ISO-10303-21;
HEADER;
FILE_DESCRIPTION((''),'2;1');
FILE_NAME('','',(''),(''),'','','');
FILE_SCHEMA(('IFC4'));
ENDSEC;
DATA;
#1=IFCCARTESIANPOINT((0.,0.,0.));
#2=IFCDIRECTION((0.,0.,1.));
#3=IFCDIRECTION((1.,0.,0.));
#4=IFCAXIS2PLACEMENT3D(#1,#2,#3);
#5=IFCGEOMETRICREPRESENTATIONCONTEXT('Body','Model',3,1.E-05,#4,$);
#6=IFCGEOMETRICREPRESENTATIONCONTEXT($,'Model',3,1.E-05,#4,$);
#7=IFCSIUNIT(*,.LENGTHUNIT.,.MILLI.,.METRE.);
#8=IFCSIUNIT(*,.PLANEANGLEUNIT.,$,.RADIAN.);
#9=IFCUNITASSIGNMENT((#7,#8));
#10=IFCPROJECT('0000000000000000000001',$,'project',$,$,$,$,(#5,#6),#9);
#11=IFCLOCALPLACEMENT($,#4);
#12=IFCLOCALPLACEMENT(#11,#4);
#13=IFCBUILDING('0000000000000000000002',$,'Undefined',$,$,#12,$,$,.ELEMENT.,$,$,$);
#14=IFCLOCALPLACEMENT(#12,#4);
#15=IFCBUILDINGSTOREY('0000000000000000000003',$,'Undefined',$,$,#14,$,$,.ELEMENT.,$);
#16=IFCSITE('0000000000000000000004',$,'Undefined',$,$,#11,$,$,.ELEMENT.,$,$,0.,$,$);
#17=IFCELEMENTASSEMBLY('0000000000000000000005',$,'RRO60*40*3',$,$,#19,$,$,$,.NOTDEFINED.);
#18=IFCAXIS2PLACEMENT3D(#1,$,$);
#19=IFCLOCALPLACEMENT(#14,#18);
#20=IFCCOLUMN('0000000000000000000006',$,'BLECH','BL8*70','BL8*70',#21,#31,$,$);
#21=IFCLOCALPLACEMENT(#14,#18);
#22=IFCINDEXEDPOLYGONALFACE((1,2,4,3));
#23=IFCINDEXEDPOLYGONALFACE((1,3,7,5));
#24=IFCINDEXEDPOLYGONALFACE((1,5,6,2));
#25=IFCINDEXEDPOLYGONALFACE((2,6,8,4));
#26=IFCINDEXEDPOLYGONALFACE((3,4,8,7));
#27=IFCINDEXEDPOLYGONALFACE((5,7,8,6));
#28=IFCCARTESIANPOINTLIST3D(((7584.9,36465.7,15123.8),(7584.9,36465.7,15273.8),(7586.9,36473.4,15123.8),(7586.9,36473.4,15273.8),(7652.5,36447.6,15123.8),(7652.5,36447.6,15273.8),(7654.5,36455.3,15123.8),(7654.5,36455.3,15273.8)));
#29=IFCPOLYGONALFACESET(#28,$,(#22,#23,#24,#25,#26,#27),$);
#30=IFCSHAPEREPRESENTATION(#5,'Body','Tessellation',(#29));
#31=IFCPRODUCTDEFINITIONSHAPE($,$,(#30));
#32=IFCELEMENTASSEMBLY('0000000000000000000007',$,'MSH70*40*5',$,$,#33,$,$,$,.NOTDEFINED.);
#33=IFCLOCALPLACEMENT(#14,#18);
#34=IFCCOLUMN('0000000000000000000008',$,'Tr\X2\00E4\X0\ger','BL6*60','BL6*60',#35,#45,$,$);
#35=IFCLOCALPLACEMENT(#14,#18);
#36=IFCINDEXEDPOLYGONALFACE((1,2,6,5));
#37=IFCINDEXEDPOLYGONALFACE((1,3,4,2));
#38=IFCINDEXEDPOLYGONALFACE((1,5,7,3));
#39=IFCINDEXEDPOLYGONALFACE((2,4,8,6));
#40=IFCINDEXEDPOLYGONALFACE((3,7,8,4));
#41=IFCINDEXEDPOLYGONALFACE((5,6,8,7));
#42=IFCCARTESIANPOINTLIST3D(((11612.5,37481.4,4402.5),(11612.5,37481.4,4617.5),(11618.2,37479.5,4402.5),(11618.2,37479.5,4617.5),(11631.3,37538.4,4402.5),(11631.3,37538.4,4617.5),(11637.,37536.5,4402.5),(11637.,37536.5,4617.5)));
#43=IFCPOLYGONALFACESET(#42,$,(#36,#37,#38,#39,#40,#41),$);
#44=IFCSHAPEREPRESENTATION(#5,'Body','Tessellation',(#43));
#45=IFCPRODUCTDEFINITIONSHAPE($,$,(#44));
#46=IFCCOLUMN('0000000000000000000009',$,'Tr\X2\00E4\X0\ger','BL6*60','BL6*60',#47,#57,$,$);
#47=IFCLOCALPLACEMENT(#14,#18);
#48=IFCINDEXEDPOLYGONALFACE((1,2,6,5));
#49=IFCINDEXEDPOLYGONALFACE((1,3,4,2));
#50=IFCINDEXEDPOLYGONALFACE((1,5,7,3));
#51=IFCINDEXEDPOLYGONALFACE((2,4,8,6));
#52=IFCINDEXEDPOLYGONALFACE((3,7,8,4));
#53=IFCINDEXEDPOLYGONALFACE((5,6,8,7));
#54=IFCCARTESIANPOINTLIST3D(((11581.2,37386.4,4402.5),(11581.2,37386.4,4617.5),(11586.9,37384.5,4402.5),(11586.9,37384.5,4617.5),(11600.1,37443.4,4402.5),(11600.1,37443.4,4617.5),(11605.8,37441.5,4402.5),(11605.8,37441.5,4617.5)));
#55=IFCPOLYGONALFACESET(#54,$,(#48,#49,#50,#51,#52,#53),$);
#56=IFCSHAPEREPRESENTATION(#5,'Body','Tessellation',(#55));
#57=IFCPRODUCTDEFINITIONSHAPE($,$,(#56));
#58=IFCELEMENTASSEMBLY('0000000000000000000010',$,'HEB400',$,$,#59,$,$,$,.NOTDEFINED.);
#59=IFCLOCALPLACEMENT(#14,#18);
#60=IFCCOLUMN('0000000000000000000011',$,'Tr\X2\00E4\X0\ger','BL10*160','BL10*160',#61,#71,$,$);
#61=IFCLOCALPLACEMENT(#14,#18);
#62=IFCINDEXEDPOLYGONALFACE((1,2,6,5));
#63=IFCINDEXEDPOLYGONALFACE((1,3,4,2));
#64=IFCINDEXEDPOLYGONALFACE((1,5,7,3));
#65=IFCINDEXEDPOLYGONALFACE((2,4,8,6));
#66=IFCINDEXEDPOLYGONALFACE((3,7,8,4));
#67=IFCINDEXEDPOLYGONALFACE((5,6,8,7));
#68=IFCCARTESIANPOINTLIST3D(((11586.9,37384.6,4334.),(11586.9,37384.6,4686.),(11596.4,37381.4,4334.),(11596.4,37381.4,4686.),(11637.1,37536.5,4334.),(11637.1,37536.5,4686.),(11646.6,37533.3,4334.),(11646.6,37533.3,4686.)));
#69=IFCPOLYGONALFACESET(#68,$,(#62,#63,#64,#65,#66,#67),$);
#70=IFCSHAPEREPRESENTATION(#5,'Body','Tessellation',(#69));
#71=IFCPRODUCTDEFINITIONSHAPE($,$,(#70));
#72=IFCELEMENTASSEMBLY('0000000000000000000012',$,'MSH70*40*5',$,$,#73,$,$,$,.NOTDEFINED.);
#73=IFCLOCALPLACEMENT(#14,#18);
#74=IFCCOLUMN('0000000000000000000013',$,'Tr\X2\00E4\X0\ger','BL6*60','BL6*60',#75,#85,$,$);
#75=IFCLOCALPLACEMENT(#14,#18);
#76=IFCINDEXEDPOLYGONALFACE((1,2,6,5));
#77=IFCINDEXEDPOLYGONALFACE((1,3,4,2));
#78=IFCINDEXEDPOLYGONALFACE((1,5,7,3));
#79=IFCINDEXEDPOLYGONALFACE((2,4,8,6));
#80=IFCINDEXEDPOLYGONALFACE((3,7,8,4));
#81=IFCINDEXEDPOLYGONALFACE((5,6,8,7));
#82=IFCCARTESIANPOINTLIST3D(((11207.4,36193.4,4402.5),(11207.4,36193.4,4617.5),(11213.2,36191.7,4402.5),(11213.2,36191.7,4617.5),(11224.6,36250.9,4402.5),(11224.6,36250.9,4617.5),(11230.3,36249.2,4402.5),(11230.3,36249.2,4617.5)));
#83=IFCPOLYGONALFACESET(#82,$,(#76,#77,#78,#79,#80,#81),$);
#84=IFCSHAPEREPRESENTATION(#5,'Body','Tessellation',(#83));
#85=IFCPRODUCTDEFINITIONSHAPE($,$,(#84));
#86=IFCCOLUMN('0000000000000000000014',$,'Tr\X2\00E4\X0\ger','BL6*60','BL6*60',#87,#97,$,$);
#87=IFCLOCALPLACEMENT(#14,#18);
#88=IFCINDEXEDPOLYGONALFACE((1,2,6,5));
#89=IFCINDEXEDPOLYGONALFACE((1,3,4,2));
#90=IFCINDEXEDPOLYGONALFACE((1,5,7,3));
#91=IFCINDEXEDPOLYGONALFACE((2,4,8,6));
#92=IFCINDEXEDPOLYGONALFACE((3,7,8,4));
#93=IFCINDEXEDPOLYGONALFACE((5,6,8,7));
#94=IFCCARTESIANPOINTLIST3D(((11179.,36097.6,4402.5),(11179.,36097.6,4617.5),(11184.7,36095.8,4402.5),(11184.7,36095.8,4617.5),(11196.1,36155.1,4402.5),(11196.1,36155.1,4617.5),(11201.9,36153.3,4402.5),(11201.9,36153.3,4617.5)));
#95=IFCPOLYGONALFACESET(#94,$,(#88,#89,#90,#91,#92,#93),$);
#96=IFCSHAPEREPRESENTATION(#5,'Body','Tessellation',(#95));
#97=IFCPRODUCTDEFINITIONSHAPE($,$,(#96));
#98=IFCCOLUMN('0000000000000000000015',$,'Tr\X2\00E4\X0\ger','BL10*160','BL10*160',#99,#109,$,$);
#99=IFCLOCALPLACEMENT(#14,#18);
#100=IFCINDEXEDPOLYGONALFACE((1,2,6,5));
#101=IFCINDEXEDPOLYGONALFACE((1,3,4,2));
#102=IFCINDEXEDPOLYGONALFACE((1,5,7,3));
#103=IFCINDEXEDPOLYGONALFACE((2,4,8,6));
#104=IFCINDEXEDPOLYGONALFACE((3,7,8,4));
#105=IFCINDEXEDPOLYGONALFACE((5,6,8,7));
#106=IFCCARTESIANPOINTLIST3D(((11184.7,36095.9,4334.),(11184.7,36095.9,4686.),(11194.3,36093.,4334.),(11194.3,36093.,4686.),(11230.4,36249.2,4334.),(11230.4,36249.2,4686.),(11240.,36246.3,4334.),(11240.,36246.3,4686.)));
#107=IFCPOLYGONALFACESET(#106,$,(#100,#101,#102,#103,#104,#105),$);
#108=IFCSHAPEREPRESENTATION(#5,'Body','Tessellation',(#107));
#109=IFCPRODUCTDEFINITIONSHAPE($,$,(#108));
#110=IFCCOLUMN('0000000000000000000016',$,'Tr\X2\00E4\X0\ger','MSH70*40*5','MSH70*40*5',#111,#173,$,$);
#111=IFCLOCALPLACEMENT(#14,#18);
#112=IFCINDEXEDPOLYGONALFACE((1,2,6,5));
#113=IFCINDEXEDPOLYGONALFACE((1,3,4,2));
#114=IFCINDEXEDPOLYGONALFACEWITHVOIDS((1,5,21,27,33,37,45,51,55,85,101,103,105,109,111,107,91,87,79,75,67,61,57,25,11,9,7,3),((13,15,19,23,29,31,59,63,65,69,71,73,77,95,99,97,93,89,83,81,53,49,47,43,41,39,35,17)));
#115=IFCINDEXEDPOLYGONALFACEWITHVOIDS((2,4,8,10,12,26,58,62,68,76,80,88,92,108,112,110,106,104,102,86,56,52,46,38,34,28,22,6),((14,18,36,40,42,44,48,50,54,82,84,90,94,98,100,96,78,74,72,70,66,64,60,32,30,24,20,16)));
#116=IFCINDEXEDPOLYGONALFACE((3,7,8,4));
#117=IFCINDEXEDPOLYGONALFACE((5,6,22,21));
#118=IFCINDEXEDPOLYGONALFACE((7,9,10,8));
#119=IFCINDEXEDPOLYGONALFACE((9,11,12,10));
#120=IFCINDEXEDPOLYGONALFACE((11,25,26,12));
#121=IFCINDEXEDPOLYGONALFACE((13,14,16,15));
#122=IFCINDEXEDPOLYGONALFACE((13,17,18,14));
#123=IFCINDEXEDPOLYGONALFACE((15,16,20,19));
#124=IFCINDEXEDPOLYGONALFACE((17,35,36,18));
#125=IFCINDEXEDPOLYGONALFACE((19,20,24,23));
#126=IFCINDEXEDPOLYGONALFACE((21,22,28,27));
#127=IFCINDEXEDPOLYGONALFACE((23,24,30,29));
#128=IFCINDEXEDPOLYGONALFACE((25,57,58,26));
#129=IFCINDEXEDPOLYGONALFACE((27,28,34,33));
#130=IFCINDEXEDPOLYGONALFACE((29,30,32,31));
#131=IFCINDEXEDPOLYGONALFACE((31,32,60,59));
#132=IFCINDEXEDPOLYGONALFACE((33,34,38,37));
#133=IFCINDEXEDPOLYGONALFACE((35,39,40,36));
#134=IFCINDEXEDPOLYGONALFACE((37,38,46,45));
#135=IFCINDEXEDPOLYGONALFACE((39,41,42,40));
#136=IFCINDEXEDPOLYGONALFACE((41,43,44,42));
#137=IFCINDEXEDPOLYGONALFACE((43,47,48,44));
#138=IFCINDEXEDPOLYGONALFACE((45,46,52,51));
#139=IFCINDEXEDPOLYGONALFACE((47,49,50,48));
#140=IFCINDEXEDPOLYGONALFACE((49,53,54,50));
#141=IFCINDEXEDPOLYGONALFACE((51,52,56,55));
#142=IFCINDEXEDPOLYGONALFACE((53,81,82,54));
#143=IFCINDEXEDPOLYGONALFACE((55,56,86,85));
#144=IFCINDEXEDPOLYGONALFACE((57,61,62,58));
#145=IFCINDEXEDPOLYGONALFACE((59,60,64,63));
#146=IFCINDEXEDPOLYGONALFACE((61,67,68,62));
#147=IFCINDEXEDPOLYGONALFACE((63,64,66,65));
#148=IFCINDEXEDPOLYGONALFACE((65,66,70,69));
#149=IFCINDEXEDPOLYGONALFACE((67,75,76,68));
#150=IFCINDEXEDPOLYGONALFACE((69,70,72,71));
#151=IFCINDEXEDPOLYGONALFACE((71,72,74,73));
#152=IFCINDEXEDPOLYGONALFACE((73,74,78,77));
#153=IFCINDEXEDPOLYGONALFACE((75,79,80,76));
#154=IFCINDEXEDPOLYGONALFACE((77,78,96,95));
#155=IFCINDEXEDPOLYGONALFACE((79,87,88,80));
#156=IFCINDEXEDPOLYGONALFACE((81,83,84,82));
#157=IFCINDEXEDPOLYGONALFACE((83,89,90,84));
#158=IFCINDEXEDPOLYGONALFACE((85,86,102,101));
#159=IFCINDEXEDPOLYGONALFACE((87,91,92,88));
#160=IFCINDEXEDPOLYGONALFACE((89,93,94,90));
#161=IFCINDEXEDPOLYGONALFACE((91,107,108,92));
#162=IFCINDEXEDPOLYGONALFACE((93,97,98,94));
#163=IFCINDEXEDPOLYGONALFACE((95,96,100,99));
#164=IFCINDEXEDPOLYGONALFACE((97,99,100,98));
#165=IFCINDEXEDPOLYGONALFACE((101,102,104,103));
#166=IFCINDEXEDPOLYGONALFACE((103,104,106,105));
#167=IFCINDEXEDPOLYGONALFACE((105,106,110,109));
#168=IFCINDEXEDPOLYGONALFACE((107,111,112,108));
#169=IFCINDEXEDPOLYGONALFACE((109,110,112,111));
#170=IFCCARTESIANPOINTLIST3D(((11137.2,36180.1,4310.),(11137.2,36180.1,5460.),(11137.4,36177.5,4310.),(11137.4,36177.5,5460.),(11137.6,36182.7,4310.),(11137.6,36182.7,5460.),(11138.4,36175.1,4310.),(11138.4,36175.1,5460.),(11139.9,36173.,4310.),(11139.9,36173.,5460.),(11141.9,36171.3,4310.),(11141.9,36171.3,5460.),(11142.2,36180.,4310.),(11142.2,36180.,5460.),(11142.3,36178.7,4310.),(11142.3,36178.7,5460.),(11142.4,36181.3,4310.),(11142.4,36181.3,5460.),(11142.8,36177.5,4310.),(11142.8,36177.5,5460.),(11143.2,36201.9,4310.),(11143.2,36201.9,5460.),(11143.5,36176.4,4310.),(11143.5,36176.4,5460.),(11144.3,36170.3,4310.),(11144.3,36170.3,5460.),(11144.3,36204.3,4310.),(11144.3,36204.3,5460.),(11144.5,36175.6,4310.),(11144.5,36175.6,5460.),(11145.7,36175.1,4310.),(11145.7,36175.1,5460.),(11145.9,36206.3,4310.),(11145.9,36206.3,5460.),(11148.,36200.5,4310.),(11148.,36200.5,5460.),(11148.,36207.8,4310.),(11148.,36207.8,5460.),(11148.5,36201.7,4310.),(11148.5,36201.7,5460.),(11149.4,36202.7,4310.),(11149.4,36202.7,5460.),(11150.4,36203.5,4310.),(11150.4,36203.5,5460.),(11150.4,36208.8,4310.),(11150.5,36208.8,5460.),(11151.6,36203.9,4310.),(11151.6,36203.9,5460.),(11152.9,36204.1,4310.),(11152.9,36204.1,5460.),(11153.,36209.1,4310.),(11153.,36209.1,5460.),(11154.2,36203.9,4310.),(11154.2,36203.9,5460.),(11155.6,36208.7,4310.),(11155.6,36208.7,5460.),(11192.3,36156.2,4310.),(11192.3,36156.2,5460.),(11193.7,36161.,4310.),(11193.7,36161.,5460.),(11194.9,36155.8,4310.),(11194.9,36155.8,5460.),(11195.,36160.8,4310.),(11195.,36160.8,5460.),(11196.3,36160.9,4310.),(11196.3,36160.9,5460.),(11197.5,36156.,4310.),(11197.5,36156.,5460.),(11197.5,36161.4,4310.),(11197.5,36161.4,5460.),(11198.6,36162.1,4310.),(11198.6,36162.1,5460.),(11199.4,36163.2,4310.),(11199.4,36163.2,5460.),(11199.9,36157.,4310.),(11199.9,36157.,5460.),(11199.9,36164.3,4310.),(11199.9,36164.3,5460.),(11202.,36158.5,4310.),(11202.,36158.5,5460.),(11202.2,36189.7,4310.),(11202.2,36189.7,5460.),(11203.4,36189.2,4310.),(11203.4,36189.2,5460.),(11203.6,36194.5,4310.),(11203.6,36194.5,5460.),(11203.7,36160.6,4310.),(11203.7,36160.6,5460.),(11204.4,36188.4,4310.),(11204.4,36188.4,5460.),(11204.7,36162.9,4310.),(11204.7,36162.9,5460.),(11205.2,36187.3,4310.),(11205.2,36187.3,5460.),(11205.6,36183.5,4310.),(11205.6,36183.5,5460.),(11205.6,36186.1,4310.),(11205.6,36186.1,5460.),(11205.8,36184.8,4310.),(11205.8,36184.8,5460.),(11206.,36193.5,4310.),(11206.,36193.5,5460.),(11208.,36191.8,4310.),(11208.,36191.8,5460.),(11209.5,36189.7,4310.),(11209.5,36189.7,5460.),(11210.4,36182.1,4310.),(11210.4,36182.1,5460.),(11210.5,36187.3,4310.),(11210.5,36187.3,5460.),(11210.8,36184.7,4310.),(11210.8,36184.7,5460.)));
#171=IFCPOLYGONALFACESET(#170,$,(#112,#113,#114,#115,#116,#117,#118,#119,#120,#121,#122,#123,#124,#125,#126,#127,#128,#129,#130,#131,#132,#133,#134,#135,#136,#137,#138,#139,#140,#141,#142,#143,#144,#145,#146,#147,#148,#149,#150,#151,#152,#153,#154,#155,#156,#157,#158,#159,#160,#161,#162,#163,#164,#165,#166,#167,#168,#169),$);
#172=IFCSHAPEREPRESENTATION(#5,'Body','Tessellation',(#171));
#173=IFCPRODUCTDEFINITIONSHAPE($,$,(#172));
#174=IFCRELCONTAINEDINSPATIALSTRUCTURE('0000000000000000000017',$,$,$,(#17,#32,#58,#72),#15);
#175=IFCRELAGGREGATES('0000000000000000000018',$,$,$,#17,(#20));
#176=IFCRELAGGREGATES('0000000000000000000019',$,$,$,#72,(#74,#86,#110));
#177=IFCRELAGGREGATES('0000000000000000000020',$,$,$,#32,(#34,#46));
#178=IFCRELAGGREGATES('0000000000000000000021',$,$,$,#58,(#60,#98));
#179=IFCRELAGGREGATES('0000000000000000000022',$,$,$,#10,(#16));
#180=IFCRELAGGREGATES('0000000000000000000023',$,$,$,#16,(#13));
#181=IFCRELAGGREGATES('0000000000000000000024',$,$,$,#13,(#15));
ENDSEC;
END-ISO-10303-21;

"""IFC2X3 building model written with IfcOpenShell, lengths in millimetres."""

from ifc_helpers import new_model, si_unit, frame, origin_with_axes, origin_2d_with_axis, place, context, project, spatial, rectangle, hollow_rectangle, extrude, element, aggregate, save


model = new_model("IFC2X3")

# Units and contexts
model_context_1 = context("Model", 3, precision=1e-05, world=origin_with_axes(), identifier="Body")
model_context_2 = context("Model", 3, precision=1e-05, world=origin_with_axes())
ifc_project = project(units=[si_unit("LENGTHUNIT", "METRE", prefix="MILLI"), si_unit("PLANEANGLEUNIT", "RADIAN")], contexts=[model_context_1, model_context_2])

# Site, building, storey
site_placement = place(None, origin_with_axes())
site = spatial("IfcSite", under=ifc_project, at=site_placement, Name="Undefined", CompositionType="ELEMENT", RefElevation=0.0)
building_placement = place(site_placement, origin_with_axes())
building = spatial("IfcBuilding", under=site, at=building_placement, Name="Undefined", CompositionType="ELEMENT")
storey_placement = place(building_placement, origin_with_axes())
storey = spatial("IfcBuildingStorey", under=building, at=storey_placement, Name="Undefined", CompositionType="ELEMENT")

# Element assembly, column
assembly_1 = element("IfcElementAssembly", 1, inside=storey, Name="RRO60*40*3", PredefinedType="NOTDEFINED")
column_1_placement = place(storey_placement, frame((7619.7, 36460.5, 15123.8), z_axis=(0.0, 0.0, 1.0), x_axis=(1.0, 0.0, 0.0)))
column_1 = element("IfcColumn", 2, at=column_1_placement, Name="BLECH", Description="BL8*70", ObjectType="BL8*70", context=model_context_1, shape_type="SweptSolid", body=[
    extrude(rectangle(XDim=8.0, YDim=70.0, at=origin_2d_with_axis()), frame((0.0, 0.0, 150.0), z_axis=(0.0, 0.0, -1.0), x_axis=(-0.25876, -0.965942, 0.000006)), (0.0, 0.0, 1.0), 150.0),
])
aggregate(assembly_1, [column_1])

# Element assembly, columns
assembly_2 = element("IfcElementAssembly", 3, inside=storey, Name="MSH70*40*5", PredefinedType="NOTDEFINED")
column_2_placement = place(storey_placement, frame((11624.8, 37508.9, 4402.5), z_axis=(0.0, 0.0, 1.0), x_axis=(1.0, 0.0, 0.0)))
column_2 = element("IfcColumn", 4, at=column_2_placement, Name="Träger", Description="BL6*60", ObjectType="BL6*60", context=model_context_1, shape_type="SweptSolid", body=[
    extrude(rectangle(XDim=6.0, YDim=60.0, at=origin_2d_with_axis()), frame((0.0, 0.0, 215.0), z_axis=(0.0, 0.0, -1.0), x_axis=(-0.949425, 0.313992, 0.0)), (0.0, 0.0, 1.0), 215.0),
])
column_3_placement = place(storey_placement, frame((11593.5, 37414.0, 4402.5), z_axis=(0.0, 0.0, 1.0), x_axis=(1.0, 0.0, 0.0)))
column_3 = element("IfcColumn", 5, at=column_3_placement, Name="Träger", Description="BL6*60", ObjectType="BL6*60", context=model_context_1, shape_type="SweptSolid", body=[
    extrude(rectangle(XDim=6.0, YDim=60.0, at=origin_2d_with_axis()), frame((0.0, 0.0, 215.0), z_axis=(0.0, 0.0, -1.0), x_axis=(-0.949425, 0.313992, 0.0)), (0.0, 0.0, 1.0), 215.0),
])

# Element assembly, column
assembly_3 = element("IfcElementAssembly", 6, inside=storey, Name="HEB400", PredefinedType="NOTDEFINED")
column_4_placement = place(storey_placement, frame((11616.7, 37458.9, 4334.0), z_axis=(0.0, 0.0, 1.0), x_axis=(1.0, 0.0, 0.0)))
column_4 = element("IfcColumn", 7, at=column_4_placement, Name="Träger", Description="BL10*160", ObjectType="BL10*160", context=model_context_1, shape_type="SweptSolid", body=[
    extrude(rectangle(XDim=10.0, YDim=160.0, at=origin_2d_with_axis()), frame((0.0, 0.0, 352.0), z_axis=(0.0, 0.0, -1.0), x_axis=(-0.949425, 0.313992, 0.0)), (0.0, 0.0, 1.0), 352.0),
])

# Element assembly, columns
assembly_4 = element("IfcElementAssembly", 8, inside=storey, Name="MSH70*40*5", PredefinedType="NOTDEFINED")
column_5_placement = place(storey_placement, frame((11218.9, 36221.3, 4402.5), z_axis=(0.0, 0.0, 1.0), x_axis=(1.0, 0.0, 0.0)))
column_5 = element("IfcColumn", 9, at=column_5_placement, Name="Träger", Description="BL6*60", ObjectType="BL6*60", context=model_context_1, shape_type="SweptSolid", body=[
    extrude(rectangle(XDim=6.0, YDim=60.0, at=origin_2d_with_axis()), frame((0.0, 0.0, 215.0), z_axis=(0.0, 0.0, -1.0), x_axis=(-0.958323, 0.285688, 0.0)), (0.0, 0.0, 1.0), 215.0),
])
column_6_placement = place(storey_placement, frame((11190.4, 36125.5, 4402.5), z_axis=(0.0, 0.0, 1.0), x_axis=(1.0, 0.0, 0.0)))
column_6 = element("IfcColumn", 10, at=column_6_placement, Name="Träger", Description="BL6*60", ObjectType="BL6*60", context=model_context_1, shape_type="SweptSolid", body=[
    extrude(rectangle(XDim=6.0, YDim=60.0, at=origin_2d_with_axis()), frame((0.0, 0.0, 215.0), z_axis=(0.0, 0.0, -1.0), x_axis=(-0.958323, 0.285688, 0.0)), (0.0, 0.0, 1.0), 215.0),
])

# Columns
column_7_placement = place(storey_placement, frame((11212.3, 36171.1, 4334.0), z_axis=(0.0, 0.0, 1.0), x_axis=(1.0, 0.0, 0.0)))
column_7 = element("IfcColumn", 11, at=column_7_placement, Name="Träger", Description="BL10*160", ObjectType="BL10*160", context=model_context_1, shape_type="SweptSolid", body=[
    extrude(rectangle(XDim=10.0, YDim=160.0, at=origin_2d_with_axis()), frame((0.0, 0.0, 352.0), z_axis=(0.0, 0.0, -1.0), x_axis=(-0.958323, 0.285688, 0.0)), (0.0, 0.0, 1.0), 352.0),
])
column_8_placement = place(storey_placement, frame((11174.0, 36182.4, 4310.0), z_axis=(0.0, 0.0, 1.0), x_axis=(1.0, 0.0, 0.0)))
column_8 = element("IfcColumn", 12, at=column_8_placement, Name="Träger", Description="MSH70*40*5", ObjectType="MSH70*40*5", context=model_context_1, shape_type="SweptSolid", body=[
    extrude(hollow_rectangle(XDim=40.0, YDim=70.0, WallThickness=5.0, InnerFilletRadius=5.0, OuterFilletRadius=10.0, at=origin_2d_with_axis()), frame((0.0, 0.0, 1150.0), z_axis=(0.0, 0.0, -1.0), x_axis=(-0.282341, -0.959314, 0.0)), (0.0, 0.0, 1.0), 1150.0),
])
aggregate(assembly_4, [column_5, column_6, column_8])
aggregate(assembly_2, [column_2, column_3])
aggregate(assembly_3, [column_4, column_7])

save(model, "model.ifc")
